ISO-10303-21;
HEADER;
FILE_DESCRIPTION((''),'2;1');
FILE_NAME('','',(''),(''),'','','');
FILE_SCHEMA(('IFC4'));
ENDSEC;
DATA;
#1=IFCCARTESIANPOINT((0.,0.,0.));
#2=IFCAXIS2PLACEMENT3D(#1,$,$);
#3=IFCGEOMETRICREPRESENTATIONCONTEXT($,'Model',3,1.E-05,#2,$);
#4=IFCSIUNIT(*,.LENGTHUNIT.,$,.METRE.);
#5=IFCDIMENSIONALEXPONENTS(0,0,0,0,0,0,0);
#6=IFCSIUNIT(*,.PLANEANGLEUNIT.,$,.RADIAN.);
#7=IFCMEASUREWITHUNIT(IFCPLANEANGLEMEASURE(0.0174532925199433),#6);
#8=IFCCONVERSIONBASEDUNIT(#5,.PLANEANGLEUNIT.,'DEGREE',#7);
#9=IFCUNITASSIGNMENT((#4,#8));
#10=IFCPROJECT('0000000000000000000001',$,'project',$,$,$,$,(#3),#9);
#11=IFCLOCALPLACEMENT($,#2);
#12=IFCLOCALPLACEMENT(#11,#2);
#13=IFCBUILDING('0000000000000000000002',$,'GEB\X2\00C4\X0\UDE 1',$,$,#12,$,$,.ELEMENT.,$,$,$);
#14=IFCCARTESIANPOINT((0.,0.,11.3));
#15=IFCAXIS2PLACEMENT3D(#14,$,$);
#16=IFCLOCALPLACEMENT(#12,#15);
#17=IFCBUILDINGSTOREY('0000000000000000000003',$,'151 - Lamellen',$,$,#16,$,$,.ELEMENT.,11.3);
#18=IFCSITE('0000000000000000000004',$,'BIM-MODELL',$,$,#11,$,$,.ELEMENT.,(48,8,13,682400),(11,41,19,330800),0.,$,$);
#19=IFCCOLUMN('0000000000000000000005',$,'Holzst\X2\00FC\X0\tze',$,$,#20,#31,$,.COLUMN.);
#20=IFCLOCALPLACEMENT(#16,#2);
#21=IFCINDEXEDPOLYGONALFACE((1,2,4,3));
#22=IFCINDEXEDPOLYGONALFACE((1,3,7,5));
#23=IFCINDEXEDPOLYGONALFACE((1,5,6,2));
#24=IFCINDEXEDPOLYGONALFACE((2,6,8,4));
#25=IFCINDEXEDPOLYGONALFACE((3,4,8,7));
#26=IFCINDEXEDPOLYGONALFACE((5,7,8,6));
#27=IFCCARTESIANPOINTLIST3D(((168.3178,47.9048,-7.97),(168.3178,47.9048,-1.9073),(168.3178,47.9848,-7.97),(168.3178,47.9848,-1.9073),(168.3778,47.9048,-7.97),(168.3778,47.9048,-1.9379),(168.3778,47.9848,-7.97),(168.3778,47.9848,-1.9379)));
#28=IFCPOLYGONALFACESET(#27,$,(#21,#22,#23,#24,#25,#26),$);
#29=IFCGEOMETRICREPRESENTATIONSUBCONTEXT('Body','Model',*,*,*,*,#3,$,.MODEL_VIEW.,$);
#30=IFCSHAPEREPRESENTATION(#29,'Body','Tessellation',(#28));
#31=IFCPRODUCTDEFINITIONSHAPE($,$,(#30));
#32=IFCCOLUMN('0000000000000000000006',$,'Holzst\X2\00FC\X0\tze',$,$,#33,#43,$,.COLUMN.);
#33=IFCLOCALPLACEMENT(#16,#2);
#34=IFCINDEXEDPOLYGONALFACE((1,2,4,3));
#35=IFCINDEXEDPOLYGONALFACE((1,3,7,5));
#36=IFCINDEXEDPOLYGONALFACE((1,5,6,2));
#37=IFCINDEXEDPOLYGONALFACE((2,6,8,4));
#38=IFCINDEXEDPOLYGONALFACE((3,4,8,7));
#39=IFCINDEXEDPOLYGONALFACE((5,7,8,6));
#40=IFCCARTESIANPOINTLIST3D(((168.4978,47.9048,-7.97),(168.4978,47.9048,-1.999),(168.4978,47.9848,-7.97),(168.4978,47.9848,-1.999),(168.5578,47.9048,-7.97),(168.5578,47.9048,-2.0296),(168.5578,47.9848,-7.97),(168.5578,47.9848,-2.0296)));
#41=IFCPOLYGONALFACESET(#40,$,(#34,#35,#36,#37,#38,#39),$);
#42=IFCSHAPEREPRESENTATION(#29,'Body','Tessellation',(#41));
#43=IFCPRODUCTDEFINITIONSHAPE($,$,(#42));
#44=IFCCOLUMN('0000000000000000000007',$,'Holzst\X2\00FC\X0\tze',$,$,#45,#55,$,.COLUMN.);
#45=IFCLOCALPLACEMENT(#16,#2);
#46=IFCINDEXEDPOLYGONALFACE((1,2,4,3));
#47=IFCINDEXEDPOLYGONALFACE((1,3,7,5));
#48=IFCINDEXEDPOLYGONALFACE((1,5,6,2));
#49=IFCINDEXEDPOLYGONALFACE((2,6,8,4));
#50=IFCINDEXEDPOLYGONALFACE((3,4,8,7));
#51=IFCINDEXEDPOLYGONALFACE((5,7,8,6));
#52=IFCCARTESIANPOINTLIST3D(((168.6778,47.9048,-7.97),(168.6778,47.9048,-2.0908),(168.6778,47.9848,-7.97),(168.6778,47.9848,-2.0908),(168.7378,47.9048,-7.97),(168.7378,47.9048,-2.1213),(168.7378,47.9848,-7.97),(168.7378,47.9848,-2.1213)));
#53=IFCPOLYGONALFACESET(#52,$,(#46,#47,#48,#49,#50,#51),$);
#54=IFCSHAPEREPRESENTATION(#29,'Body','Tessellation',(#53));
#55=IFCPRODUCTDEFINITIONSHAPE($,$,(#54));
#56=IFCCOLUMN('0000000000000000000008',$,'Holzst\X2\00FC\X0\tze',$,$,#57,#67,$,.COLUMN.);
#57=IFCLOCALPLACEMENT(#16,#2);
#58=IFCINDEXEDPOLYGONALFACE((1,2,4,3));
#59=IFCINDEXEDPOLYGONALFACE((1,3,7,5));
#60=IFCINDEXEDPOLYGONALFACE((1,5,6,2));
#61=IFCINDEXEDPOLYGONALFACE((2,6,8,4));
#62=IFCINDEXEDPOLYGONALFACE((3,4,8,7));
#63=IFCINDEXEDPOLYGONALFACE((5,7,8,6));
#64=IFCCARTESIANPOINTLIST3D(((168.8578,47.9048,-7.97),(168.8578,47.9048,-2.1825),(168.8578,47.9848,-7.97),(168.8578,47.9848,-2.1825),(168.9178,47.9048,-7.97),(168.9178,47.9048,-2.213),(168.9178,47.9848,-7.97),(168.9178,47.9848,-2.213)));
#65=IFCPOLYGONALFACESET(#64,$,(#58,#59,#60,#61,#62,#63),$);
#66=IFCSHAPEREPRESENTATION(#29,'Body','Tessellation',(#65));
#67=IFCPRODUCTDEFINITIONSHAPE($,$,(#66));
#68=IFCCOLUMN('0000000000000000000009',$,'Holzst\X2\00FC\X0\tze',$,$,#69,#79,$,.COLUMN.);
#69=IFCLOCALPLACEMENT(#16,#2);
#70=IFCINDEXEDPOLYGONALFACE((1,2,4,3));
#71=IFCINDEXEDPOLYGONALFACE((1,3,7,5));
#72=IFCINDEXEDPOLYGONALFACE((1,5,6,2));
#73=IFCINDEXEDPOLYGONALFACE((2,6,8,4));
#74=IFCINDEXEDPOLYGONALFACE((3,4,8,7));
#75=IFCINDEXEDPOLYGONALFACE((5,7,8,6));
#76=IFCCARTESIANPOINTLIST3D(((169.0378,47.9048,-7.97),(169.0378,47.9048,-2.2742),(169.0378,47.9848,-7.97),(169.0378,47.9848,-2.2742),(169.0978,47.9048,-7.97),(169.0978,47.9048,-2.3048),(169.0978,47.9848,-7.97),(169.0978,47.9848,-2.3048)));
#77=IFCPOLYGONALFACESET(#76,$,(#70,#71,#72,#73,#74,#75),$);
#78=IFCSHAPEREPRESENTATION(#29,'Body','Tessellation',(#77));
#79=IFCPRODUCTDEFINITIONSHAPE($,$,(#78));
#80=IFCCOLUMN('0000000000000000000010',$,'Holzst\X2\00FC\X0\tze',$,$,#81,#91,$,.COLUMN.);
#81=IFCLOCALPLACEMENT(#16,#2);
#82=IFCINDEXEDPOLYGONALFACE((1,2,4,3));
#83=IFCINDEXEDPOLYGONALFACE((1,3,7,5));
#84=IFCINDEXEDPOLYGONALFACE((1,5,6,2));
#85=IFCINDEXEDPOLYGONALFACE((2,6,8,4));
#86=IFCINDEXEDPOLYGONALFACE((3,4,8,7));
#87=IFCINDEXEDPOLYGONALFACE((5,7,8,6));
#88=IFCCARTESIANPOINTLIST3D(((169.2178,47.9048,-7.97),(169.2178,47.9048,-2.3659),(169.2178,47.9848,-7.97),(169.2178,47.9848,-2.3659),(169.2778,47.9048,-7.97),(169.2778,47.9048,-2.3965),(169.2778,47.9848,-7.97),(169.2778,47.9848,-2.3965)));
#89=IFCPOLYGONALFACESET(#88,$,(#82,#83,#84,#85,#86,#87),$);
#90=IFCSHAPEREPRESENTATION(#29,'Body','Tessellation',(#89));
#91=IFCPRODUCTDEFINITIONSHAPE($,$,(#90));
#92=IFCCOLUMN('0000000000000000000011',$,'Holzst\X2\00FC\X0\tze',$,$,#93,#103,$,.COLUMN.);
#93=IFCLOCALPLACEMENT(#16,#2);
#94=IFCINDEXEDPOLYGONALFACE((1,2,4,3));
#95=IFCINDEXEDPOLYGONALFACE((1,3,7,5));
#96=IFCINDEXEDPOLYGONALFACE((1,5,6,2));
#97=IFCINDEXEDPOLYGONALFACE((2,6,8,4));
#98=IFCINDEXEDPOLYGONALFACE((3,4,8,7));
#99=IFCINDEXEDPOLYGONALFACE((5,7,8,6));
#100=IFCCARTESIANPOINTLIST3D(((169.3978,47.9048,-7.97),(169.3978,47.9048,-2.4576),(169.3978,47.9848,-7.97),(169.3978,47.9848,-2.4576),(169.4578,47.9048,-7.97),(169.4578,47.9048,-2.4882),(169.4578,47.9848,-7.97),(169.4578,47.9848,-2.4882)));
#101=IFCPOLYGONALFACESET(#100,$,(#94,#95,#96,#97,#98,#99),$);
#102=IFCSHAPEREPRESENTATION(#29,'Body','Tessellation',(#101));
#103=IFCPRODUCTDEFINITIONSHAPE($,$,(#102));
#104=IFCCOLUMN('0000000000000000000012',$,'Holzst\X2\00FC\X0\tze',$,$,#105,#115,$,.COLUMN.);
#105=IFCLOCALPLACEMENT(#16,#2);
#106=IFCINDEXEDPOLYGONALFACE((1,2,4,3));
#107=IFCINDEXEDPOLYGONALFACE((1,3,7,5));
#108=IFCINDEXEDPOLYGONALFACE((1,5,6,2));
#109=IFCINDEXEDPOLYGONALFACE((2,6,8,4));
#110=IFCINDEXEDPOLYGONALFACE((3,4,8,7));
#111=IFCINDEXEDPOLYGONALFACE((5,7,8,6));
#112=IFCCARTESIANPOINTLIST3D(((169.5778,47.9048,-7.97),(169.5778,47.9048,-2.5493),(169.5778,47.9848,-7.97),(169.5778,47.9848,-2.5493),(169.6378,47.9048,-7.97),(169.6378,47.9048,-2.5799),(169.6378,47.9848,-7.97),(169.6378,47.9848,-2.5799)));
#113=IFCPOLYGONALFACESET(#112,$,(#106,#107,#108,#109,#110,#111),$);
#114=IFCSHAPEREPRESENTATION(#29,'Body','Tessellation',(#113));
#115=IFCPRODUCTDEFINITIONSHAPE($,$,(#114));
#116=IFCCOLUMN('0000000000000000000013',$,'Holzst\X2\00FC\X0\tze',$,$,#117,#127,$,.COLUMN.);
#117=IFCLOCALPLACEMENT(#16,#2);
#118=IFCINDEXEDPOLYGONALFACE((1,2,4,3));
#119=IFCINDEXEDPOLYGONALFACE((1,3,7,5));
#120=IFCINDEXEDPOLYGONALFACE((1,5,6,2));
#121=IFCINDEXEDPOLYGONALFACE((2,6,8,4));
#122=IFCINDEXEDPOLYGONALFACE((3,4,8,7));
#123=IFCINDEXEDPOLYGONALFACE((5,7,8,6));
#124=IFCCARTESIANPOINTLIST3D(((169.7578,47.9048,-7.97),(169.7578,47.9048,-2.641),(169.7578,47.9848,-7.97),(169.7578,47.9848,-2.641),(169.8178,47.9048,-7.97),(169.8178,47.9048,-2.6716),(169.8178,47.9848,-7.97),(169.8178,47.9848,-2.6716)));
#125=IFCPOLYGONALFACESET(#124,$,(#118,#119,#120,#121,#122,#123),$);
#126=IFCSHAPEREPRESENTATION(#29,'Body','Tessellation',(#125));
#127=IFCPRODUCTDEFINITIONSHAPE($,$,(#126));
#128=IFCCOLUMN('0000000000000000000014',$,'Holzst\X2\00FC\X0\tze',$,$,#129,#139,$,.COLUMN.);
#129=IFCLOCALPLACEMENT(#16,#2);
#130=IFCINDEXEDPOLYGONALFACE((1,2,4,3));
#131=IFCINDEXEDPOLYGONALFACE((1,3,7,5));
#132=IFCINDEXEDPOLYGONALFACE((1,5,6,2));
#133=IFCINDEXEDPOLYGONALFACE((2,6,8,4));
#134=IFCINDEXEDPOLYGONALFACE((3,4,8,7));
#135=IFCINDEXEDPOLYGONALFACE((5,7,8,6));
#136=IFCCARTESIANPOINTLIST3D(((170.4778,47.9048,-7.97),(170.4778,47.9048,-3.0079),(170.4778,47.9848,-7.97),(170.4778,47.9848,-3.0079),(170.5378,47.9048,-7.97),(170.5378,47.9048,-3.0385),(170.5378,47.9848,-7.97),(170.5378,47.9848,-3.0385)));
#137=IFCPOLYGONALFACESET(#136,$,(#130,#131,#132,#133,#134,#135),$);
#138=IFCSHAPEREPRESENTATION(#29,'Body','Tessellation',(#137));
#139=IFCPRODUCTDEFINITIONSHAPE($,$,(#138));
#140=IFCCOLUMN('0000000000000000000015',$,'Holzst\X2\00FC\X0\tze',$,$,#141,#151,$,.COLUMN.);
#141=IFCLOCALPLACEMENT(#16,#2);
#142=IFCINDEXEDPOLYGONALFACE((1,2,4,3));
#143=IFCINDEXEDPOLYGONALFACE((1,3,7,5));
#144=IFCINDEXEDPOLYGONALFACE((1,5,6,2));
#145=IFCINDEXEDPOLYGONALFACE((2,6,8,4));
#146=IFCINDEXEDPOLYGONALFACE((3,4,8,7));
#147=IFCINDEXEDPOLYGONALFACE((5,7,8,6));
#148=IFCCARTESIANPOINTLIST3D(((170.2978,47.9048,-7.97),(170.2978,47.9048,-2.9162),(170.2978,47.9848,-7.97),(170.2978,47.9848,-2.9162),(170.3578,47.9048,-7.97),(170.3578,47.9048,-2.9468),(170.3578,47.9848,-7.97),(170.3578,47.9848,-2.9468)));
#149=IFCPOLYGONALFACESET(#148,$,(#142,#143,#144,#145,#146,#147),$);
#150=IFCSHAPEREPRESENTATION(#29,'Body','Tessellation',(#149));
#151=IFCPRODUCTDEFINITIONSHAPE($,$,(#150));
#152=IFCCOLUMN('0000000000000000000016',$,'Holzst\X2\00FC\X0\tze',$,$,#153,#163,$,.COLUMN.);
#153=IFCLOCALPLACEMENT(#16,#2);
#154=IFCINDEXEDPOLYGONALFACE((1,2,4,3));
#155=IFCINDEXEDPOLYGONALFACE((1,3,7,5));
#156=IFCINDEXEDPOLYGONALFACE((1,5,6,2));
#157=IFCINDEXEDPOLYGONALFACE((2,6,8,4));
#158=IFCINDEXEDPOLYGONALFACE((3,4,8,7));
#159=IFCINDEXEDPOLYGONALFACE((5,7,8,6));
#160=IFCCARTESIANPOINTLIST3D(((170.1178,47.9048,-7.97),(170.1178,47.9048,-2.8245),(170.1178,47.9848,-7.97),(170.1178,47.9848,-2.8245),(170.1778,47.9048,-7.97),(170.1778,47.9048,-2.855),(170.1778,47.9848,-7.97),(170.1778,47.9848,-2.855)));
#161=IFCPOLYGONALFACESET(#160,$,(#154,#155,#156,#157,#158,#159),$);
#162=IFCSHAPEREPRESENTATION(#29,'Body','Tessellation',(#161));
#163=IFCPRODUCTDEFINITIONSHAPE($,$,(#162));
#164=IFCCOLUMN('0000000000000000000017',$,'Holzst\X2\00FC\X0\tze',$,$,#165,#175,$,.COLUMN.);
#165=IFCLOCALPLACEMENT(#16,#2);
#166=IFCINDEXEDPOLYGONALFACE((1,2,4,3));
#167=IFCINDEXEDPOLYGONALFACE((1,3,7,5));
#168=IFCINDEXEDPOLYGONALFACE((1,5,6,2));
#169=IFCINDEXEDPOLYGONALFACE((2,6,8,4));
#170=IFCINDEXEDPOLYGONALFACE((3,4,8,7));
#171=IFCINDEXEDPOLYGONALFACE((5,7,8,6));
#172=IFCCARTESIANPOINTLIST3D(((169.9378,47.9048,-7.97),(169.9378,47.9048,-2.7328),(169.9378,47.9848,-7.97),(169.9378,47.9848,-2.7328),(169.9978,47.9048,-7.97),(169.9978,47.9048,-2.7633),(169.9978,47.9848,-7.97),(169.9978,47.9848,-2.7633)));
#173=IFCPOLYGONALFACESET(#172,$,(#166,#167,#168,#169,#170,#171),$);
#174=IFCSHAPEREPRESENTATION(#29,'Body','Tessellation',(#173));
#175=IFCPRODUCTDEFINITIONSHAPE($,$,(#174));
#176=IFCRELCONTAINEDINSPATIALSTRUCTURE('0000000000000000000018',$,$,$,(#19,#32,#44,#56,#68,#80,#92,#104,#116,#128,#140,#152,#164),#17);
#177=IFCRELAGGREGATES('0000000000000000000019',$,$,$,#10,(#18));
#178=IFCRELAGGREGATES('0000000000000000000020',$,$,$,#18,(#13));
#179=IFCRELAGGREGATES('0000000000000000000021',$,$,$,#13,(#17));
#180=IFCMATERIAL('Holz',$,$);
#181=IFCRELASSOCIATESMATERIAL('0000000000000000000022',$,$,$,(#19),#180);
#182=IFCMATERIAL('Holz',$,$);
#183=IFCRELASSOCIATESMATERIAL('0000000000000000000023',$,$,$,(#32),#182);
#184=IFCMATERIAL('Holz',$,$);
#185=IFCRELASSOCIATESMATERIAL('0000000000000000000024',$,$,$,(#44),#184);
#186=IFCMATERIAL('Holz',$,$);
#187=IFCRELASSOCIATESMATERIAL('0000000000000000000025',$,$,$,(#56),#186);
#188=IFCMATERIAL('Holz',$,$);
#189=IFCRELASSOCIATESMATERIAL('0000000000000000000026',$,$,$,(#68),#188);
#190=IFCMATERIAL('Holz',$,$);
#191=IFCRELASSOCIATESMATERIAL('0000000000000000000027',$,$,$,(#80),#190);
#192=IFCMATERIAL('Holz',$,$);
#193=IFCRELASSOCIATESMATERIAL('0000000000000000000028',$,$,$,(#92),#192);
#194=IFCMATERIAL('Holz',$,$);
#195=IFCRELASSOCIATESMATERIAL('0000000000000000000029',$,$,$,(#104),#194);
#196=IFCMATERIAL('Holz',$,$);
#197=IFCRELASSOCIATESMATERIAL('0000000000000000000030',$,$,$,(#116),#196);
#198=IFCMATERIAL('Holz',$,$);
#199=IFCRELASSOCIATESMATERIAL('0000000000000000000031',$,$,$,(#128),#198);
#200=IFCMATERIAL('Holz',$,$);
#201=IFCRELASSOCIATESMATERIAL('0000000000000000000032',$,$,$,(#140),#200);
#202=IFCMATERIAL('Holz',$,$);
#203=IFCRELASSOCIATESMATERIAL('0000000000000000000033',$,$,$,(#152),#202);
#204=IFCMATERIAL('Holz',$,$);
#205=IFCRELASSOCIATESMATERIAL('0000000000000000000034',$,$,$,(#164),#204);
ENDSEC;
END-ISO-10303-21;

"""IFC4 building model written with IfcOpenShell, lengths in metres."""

from ifc_helpers import new_model, entity, si_unit, converted_unit, frame, frame_2d, origin, origin_with_axes, place, context, subcontext, project, spatial, rectangle, extrude, clip, halfspace, material, element, save


model = new_model("IFC4")

# Units and contexts
model_context = context("Model", 3, precision=1e-05, world=origin())
body_context = subcontext(model_context, "Body", "Model", "MODEL_VIEW")
ifc_project = project(units=[si_unit("LENGTHUNIT", "METRE"), converted_unit("PLANEANGLEUNIT", "DEGREE", entity("IfcPlaneAngleMeasure", 0.0174532925199433), si_unit("PLANEANGLEUNIT", "RADIAN"), dimensions=[0, 0, 0, 0, 0, 0, 0])], contexts=[model_context])

# Site, building, storey
site_placement = place(None, origin())
site = spatial("IfcSite", under=ifc_project, at=site_placement, Name="BIM-MODELL", CompositionType="ELEMENT", RefLatitude=(48, 8, 13, 682400), RefLongitude=(11, 41, 19, 330800), RefElevation=0.0)
building_placement = place(site_placement, origin())
building = spatial("IfcBuilding", under=site, at=building_placement, Name="GEBÄUDE 1", CompositionType="ELEMENT")
storey_placement = place(building_placement, frame((0.0, 0.0, 11.3)))
storey = spatial("IfcBuildingStorey", under=building, at=storey_placement, Name="151 - Lamellen", CompositionType="ELEMENT", Elevation=11.3)

# Columns
ifc_material_1 = material(Name="Holz")
column_1_placement = place(storey_placement, frame((168.3178, 47.9048, -7.97)))
element("IfcColumn", 1, at=column_1_placement, inside=storey, material=ifc_material_1, Name="Holzstütze", PredefinedType="COLUMN", context=body_context, shape_type="Clipping", body=[
    clip(extrude(rectangle(XDim=0.06, YDim=0.08, at=frame_2d((0.03, 0.04), x_axis=(1.0, 0.0))), origin_with_axes(), (0.0, 0.0, 1.0), 6.0627), halfspace(frame((0.03, 0.04, 6.0474), z_axis=(-0.45399, 0.0, -0.891007), x_axis=(0.0, 1.0, 0.0)), True)),
])
ifc_material_2 = material(Name="Holz")
column_2_placement = place(storey_placement, frame((168.4978, 47.9048, -7.97)))
element("IfcColumn", 2, at=column_2_placement, inside=storey, material=ifc_material_2, Name="Holzstütze", PredefinedType="COLUMN", context=body_context, shape_type="Clipping", body=[
    clip(extrude(rectangle(XDim=0.06, YDim=0.08, at=frame_2d((0.03, 0.04), x_axis=(1.0, 0.0))), origin_with_axes(), (0.0, 0.0, 1.0), 5.971), halfspace(frame((0.03, 0.04, 5.9557), z_axis=(-0.45399, 0.0, -0.891007), x_axis=(0.0, 1.0, 0.0)), True)),
])
ifc_material_3 = material(Name="Holz")
column_3_placement = place(storey_placement, frame((168.6778, 47.9048, -7.97)))
element("IfcColumn", 3, at=column_3_placement, inside=storey, material=ifc_material_3, Name="Holzstütze", PredefinedType="COLUMN", context=body_context, shape_type="Clipping", body=[
    clip(extrude(rectangle(XDim=0.06, YDim=0.08, at=frame_2d((0.03, 0.04), x_axis=(1.0, 0.0))), origin_with_axes(), (0.0, 0.0, 1.0), 5.8792), halfspace(frame((0.03, 0.04, 5.864), z_axis=(-0.45399, 0.0, -0.891007), x_axis=(0.0, 1.0, 0.0)), True)),
])
ifc_material_4 = material(Name="Holz")
column_4_placement = place(storey_placement, frame((168.8578, 47.9048, -7.97)))
element("IfcColumn", 4, at=column_4_placement, inside=storey, material=ifc_material_4, Name="Holzstütze", PredefinedType="COLUMN", context=body_context, shape_type="Clipping", body=[
    clip(extrude(rectangle(XDim=0.06, YDim=0.08, at=frame_2d((0.03, 0.04), x_axis=(1.0, 0.0))), origin_with_axes(), (0.0, 0.0, 1.0), 5.7875), halfspace(frame((0.03, 0.04, 5.7722), z_axis=(-0.45399, 0.0, -0.891007), x_axis=(0.0, 1.0, 0.0)), True)),
])
ifc_material_5 = material(Name="Holz")
column_5_placement = place(storey_placement, frame((169.0378, 47.9048, -7.97)))
element("IfcColumn", 5, at=column_5_placement, inside=storey, material=ifc_material_5, Name="Holzstütze", PredefinedType="COLUMN", context=body_context, shape_type="Clipping", body=[
    clip(extrude(rectangle(XDim=0.06, YDim=0.08, at=frame_2d((0.03, 0.04), x_axis=(1.0, 0.0))), origin_with_axes(), (0.0, 0.0, 1.0), 5.6958), halfspace(frame((0.03, 0.04, 5.6805), z_axis=(-0.45399, 0.0, -0.891007), x_axis=(0.0, 1.0, 0.0)), True)),
])
ifc_material_6 = material(Name="Holz")
column_6_placement = place(storey_placement, frame((169.2178, 47.9048, -7.97)))
element("IfcColumn", 6, at=column_6_placement, inside=storey, material=ifc_material_6, Name="Holzstütze", PredefinedType="COLUMN", context=body_context, shape_type="Clipping", body=[
    clip(extrude(rectangle(XDim=0.06, YDim=0.08, at=frame_2d((0.03, 0.04), x_axis=(1.0, 0.0))), origin_with_axes(), (0.0, 0.0, 1.0), 5.6041), halfspace(frame((0.03, 0.04, 5.5888), z_axis=(-0.45399, 0.0, -0.891007), x_axis=(0.0, 1.0, 0.0)), True)),
])
ifc_material_7 = material(Name="Holz")
column_7_placement = place(storey_placement, frame((169.3978, 47.9048, -7.97)))
element("IfcColumn", 7, at=column_7_placement, inside=storey, material=ifc_material_7, Name="Holzstütze", PredefinedType="COLUMN", context=body_context, shape_type="Clipping", body=[
    clip(extrude(rectangle(XDim=0.06, YDim=0.08, at=frame_2d((0.03, 0.04), x_axis=(1.0, 0.0))), origin_with_axes(), (0.0, 0.0, 1.0), 5.5124), halfspace(frame((0.03, 0.04, 5.4971), z_axis=(-0.45399, 0.0, -0.891007), x_axis=(0.0, 1.0, 0.0)), True)),
])
ifc_material_8 = material(Name="Holz")
column_8_placement = place(storey_placement, frame((169.5778, 47.9048, -7.97)))
element("IfcColumn", 8, at=column_8_placement, inside=storey, material=ifc_material_8, Name="Holzstütze", PredefinedType="COLUMN", context=body_context, shape_type="Clipping", body=[
    clip(extrude(rectangle(XDim=0.06, YDim=0.08, at=frame_2d((0.03, 0.04), x_axis=(1.0, 0.0))), origin_with_axes(), (0.0, 0.0, 1.0), 5.4207), halfspace(frame((0.03, 0.04, 5.4054), z_axis=(-0.45399, 0.0, -0.891007), x_axis=(0.0, 1.0, 0.0)), True)),
])
ifc_material_9 = material(Name="Holz")
column_9_placement = place(storey_placement, frame((169.7578, 47.9048, -7.97)))
element("IfcColumn", 9, at=column_9_placement, inside=storey, material=ifc_material_9, Name="Holzstütze", PredefinedType="COLUMN", context=body_context, shape_type="Clipping", body=[
    clip(extrude(rectangle(XDim=0.06, YDim=0.08, at=frame_2d((0.03, 0.04), x_axis=(1.0, 0.0))), origin_with_axes(), (0.0, 0.0, 1.0), 5.329), halfspace(frame((0.03, 0.04, 5.3137), z_axis=(-0.45399, 0.0, -0.891007), x_axis=(0.0, 1.0, 0.0)), True)),
])
ifc_material_10 = material(Name="Holz")
column_10_placement = place(storey_placement, frame((170.4778, 47.9048, -7.97)))
element("IfcColumn", 10, at=column_10_placement, inside=storey, material=ifc_material_10, Name="Holzstütze", PredefinedType="COLUMN", context=body_context, shape_type="Clipping", body=[
    clip(extrude(rectangle(XDim=0.06, YDim=0.08, at=frame_2d((0.03, 0.04), x_axis=(1.0, 0.0))), origin_with_axes(), (0.0, 0.0, 1.0), 4.9621), halfspace(frame((0.03, 0.04, 4.9468), z_axis=(-0.45399, 0.0, -0.891007), x_axis=(0.0, 1.0, 0.0)), True)),
])
ifc_material_11 = material(Name="Holz")
column_11_placement = place(storey_placement, frame((170.2978, 47.9048, -7.97)))
element("IfcColumn", 11, at=column_11_placement, inside=storey, material=ifc_material_11, Name="Holzstütze", PredefinedType="COLUMN", context=body_context, shape_type="Clipping", body=[
    clip(extrude(rectangle(XDim=0.06, YDim=0.08, at=frame_2d((0.03, 0.04), x_axis=(1.0, 0.0))), origin_with_axes(), (0.0, 0.0, 1.0), 5.0538), halfspace(frame((0.03, 0.04, 5.0385), z_axis=(-0.45399, 0.0, -0.891007), x_axis=(0.0, 1.0, 0.0)), True)),
])
ifc_material_12 = material(Name="Holz")
column_12_placement = place(storey_placement, frame((170.1178, 47.9048, -7.97)))
element("IfcColumn", 12, at=column_12_placement, inside=storey, material=ifc_material_12, Name="Holzstütze", PredefinedType="COLUMN", context=body_context, shape_type="Clipping", body=[
    clip(extrude(rectangle(XDim=0.06, YDim=0.08, at=frame_2d((0.03, 0.04), x_axis=(1.0, 0.0))), origin_with_axes(), (0.0, 0.0, 1.0), 5.1455), halfspace(frame((0.03, 0.04, 5.1302), z_axis=(-0.45399, 0.0, -0.891007), x_axis=(0.0, 1.0, 0.0)), True)),
])
ifc_material_13 = material(Name="Holz")
column_13_placement = place(storey_placement, frame((169.9378, 47.9048, -7.97)))
element("IfcColumn", 13, at=column_13_placement, inside=storey, material=ifc_material_13, Name="Holzstütze", PredefinedType="COLUMN", context=body_context, shape_type="Clipping", body=[
    clip(extrude(rectangle(XDim=0.06, YDim=0.08, at=frame_2d((0.03, 0.04), x_axis=(1.0, 0.0))), origin_with_axes(), (0.0, 0.0, 1.0), 5.2372), halfspace(frame((0.03, 0.04, 5.222), z_axis=(-0.45399, 0.0, -0.891007), x_axis=(0.0, 1.0, 0.0)), True)),
])

save(model, "model.ifc")
